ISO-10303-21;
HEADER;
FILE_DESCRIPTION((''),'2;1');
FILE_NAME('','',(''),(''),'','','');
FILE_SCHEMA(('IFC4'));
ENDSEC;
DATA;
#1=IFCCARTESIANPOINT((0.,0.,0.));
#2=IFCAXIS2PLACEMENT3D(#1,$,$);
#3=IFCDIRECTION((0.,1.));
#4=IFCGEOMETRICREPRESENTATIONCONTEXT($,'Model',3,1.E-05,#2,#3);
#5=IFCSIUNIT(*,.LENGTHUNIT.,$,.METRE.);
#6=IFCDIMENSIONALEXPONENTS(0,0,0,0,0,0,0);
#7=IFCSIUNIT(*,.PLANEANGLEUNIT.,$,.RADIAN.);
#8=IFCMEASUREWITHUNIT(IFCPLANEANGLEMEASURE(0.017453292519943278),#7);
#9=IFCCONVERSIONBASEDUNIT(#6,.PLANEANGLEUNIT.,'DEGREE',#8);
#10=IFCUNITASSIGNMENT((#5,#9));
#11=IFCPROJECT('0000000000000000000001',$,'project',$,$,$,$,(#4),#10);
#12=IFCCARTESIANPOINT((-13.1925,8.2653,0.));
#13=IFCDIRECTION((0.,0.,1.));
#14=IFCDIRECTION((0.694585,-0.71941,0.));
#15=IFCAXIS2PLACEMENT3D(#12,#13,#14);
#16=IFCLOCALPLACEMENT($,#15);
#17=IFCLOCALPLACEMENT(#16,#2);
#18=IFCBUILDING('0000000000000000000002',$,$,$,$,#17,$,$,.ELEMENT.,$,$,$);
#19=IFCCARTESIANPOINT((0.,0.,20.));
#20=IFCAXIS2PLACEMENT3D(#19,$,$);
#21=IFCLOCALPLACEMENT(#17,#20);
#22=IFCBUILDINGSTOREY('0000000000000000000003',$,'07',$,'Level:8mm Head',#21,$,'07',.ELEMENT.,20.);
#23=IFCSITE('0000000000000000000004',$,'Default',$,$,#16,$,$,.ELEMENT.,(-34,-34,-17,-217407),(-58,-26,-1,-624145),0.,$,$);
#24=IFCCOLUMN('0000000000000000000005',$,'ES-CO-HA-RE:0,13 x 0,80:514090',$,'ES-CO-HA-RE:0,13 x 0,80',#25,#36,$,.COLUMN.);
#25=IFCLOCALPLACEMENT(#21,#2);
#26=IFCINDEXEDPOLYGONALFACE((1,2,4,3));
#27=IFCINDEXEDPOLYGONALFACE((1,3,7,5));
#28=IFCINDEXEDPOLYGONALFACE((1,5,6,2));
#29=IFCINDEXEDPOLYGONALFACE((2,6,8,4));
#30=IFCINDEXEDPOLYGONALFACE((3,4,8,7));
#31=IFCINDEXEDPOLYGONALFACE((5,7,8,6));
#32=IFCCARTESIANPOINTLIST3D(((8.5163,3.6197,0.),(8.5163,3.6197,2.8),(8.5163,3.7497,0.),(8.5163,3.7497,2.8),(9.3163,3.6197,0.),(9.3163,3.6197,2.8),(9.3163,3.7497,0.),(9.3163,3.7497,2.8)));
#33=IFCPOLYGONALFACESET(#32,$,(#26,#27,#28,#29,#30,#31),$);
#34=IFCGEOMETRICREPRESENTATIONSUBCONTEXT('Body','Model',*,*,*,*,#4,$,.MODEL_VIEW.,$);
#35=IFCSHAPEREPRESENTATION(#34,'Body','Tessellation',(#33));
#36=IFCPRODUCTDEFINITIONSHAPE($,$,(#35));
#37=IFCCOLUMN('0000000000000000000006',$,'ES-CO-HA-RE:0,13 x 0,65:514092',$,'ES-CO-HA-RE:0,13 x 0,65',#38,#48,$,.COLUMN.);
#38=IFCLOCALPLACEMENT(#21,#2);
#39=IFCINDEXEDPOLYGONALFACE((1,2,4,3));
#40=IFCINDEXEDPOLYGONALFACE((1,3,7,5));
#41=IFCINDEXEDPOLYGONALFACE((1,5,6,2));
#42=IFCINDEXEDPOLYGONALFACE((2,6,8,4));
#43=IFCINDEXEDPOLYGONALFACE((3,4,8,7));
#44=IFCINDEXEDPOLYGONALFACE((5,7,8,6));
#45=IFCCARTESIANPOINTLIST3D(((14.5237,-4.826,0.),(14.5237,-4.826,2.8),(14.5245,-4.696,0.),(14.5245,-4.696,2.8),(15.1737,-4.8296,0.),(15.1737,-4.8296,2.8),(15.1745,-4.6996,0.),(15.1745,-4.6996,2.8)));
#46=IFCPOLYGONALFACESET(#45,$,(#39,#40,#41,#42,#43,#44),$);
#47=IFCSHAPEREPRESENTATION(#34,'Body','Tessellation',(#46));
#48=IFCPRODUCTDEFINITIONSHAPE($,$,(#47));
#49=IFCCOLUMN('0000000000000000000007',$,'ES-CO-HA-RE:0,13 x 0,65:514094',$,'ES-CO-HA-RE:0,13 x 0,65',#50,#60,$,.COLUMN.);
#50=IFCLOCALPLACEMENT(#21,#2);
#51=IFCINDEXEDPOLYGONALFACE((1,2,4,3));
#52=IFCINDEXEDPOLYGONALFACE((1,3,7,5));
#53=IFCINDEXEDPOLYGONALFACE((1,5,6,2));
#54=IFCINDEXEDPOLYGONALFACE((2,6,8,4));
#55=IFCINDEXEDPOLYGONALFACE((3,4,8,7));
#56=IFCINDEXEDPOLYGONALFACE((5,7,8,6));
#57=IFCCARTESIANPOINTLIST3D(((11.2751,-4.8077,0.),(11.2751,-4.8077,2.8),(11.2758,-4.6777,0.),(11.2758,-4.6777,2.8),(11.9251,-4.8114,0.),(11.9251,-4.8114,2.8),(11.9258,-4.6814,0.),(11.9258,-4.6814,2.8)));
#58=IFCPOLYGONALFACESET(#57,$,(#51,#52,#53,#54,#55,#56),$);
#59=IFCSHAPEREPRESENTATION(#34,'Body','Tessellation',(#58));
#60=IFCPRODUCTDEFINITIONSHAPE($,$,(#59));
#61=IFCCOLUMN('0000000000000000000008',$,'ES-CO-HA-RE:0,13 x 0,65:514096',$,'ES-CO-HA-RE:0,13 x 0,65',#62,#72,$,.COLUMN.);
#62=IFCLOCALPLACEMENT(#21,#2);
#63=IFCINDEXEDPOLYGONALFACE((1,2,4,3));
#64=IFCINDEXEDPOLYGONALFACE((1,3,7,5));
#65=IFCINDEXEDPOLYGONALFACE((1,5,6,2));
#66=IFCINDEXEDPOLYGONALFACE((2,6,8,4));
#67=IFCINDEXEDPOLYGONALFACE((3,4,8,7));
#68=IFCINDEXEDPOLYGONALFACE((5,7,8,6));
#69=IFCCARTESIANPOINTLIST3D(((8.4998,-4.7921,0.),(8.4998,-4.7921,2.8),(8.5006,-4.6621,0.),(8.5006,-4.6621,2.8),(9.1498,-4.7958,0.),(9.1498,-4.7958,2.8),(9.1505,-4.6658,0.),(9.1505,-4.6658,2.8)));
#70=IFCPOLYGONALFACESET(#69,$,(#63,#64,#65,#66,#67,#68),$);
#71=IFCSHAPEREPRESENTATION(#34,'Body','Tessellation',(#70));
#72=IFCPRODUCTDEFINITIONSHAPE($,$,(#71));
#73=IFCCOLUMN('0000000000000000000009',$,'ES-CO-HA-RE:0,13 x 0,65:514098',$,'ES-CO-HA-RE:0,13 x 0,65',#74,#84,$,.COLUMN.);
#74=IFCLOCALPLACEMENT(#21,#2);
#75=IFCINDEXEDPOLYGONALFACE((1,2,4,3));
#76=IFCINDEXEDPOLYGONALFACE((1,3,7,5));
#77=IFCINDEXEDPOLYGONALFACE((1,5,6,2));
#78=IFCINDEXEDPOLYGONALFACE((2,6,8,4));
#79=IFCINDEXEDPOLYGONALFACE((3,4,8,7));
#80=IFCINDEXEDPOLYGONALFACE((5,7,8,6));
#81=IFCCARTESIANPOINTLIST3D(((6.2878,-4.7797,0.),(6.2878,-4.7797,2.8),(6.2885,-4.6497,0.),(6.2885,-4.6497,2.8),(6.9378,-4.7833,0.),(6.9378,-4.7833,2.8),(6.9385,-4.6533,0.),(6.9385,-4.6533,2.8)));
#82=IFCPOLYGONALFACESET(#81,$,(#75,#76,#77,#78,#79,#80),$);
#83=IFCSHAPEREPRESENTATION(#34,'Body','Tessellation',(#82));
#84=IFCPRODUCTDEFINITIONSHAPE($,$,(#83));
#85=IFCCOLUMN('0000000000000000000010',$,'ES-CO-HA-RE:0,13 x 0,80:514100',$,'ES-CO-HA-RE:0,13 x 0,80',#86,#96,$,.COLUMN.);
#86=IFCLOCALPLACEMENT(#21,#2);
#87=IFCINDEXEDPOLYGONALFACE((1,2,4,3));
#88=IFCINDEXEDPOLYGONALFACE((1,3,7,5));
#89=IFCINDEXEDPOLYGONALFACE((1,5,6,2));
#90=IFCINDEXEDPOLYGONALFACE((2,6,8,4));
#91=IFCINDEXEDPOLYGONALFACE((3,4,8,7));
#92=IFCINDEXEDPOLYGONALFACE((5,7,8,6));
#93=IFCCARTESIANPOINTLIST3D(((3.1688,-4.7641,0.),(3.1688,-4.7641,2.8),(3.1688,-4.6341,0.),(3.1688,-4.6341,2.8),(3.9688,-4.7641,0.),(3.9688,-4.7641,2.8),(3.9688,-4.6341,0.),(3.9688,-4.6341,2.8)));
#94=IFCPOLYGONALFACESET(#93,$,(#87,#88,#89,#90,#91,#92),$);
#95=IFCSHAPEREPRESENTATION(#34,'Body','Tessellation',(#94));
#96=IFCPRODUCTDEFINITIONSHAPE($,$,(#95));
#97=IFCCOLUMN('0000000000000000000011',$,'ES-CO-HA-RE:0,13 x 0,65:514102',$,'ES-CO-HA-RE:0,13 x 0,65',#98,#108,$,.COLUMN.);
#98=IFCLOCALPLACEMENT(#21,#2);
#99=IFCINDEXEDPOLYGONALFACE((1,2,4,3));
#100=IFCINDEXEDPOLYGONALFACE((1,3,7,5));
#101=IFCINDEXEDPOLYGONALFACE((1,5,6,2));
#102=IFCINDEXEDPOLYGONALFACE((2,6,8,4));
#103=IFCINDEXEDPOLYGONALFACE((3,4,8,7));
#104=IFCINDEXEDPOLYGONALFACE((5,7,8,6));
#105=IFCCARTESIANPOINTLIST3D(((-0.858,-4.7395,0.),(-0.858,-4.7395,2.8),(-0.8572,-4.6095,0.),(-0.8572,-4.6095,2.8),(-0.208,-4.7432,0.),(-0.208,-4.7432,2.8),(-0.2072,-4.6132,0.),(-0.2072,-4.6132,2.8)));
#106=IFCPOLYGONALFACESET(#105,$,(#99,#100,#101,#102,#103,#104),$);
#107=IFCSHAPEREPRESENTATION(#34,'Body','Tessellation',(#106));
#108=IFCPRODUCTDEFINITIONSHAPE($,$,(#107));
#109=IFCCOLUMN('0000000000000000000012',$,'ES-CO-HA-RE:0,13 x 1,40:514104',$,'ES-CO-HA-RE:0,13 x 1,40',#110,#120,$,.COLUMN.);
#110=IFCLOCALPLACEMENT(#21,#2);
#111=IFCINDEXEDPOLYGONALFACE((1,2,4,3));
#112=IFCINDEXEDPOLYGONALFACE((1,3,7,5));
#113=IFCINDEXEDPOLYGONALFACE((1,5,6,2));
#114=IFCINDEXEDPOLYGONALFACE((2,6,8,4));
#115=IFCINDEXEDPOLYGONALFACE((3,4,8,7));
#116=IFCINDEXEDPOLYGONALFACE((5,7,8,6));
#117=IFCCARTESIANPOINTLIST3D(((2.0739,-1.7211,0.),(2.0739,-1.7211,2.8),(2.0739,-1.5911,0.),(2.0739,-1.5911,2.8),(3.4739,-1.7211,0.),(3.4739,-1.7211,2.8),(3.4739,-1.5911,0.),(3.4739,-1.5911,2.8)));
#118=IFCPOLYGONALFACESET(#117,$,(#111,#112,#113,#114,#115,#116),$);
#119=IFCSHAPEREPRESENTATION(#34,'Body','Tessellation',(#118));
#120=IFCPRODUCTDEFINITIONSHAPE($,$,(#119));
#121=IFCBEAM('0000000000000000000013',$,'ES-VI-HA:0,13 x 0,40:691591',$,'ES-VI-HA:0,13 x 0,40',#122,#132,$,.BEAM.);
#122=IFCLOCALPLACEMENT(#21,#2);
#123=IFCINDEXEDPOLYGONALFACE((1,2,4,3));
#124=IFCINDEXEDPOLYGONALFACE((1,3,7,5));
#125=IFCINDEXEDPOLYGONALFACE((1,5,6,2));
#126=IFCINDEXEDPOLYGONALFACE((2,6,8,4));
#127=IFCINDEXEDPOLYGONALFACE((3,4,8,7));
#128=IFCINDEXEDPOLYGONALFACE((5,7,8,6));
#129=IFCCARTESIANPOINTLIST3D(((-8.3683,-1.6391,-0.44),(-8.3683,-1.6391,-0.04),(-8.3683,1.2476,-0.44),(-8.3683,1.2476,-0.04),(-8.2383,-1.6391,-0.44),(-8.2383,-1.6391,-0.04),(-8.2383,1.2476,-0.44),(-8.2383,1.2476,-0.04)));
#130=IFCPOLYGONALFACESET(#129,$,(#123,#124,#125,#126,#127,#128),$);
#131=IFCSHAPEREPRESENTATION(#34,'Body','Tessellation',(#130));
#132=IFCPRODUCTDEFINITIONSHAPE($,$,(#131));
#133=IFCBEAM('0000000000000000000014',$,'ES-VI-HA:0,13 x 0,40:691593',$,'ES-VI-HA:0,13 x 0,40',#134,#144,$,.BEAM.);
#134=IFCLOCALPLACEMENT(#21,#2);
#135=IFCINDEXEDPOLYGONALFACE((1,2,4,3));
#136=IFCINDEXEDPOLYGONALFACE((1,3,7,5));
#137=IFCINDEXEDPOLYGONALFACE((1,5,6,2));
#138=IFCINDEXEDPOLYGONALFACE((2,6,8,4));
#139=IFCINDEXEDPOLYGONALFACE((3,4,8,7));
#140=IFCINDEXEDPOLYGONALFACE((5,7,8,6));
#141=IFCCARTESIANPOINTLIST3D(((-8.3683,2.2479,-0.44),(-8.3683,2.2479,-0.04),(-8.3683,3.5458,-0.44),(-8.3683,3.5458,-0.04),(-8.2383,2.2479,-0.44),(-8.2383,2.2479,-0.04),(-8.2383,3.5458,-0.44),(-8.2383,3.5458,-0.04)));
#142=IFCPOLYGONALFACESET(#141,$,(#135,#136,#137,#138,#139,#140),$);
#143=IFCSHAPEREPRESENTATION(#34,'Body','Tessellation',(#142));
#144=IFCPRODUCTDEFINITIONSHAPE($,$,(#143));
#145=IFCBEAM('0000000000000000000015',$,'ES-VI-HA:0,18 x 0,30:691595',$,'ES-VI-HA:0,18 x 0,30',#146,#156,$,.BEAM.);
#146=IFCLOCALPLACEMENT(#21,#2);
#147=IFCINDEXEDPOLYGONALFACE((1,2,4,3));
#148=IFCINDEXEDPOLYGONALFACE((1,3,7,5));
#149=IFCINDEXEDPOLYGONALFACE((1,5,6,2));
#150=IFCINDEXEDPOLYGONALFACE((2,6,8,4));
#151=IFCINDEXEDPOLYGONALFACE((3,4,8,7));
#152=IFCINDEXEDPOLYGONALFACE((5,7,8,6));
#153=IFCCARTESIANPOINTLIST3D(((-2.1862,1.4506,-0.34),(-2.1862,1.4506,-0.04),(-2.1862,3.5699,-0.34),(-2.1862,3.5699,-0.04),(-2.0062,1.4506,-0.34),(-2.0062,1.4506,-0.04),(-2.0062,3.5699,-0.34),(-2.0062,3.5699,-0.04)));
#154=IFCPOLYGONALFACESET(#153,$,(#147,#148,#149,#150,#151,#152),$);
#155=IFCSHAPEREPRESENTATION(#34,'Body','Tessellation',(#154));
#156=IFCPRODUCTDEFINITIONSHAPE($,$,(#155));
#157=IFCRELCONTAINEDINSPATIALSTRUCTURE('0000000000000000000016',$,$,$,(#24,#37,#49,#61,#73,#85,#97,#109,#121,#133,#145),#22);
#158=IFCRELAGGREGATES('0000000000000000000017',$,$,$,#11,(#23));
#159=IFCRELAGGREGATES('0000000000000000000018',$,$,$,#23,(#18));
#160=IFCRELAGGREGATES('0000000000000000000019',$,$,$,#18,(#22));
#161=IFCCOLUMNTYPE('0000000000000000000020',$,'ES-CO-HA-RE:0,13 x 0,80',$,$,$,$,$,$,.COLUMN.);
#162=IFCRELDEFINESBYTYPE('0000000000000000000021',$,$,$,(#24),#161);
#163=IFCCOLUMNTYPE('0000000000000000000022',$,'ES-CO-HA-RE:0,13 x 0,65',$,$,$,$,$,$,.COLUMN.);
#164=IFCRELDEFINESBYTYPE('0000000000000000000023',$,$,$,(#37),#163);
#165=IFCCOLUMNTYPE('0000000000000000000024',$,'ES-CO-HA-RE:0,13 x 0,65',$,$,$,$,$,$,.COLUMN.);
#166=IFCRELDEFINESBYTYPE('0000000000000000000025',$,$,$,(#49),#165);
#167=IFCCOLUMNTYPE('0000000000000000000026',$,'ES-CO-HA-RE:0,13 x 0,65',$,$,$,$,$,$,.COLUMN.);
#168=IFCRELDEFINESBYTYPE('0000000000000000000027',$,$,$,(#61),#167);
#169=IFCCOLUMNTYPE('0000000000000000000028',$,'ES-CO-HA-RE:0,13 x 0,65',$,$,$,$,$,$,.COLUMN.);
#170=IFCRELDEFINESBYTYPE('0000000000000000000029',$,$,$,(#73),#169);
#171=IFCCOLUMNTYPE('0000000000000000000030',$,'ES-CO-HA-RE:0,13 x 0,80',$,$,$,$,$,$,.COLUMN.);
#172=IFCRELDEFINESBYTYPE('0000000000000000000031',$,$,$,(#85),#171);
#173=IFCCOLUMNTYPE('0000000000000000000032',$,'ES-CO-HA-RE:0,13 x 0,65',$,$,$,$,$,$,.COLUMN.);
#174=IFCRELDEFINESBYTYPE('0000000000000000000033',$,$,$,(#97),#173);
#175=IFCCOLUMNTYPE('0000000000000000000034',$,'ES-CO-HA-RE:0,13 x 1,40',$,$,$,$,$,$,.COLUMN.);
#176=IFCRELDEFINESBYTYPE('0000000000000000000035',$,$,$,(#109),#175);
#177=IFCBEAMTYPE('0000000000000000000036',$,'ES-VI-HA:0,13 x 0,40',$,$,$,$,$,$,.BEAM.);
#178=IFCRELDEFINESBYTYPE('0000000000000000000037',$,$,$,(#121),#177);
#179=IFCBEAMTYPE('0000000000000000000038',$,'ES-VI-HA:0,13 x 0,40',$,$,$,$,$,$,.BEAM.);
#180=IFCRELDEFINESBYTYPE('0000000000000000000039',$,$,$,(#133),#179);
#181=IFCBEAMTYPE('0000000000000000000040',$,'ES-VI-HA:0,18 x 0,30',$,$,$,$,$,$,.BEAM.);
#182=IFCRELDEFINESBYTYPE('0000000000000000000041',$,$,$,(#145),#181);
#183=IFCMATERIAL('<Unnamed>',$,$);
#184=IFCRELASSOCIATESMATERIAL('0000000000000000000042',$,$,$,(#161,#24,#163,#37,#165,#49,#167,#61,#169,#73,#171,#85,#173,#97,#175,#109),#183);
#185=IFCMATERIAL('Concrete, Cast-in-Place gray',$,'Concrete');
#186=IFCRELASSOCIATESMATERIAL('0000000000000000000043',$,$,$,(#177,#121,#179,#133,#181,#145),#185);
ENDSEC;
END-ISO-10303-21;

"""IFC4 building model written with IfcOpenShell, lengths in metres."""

from ifc_helpers import new_model, entity, si_unit, converted_unit, direction, frame, origin, place, context, subcontext, project, spatial, indexed_curve, outline, extrude, source, transform, mapped, material, type_object, type_shapes, element, save


model = new_model("IFC4")

# Units and contexts
model_context = context("Model", 3, precision=1e-05, world=origin(), true_north=direction((0.0, 1.0)))
body_context = subcontext(model_context, "Body", "Model", "MODEL_VIEW")
ifc_project = project(units=[si_unit("LENGTHUNIT", "METRE"), converted_unit("PLANEANGLEUNIT", "DEGREE", entity("IfcPlaneAngleMeasure", 0.017453292519943278), si_unit("PLANEANGLEUNIT", "RADIAN"), dimensions=[0, 0, 0, 0, 0, 0, 0])], contexts=[model_context])

# Site, building, storey
site_placement = place(None, frame((-13.1925, 8.2653, 0.0), z_axis=(0.0, 0.0, 1.0), x_axis=(0.694585, -0.71941, 0.0)))
site = spatial("IfcSite", under=ifc_project, at=site_placement, Name="Default", CompositionType="ELEMENT", RefLatitude=(-34, -34, -17, -217407), RefLongitude=(-58, -26, -1, -624145), RefElevation=0.0)
building_placement = place(site_placement, origin())
building = spatial("IfcBuilding", under=site, at=building_placement, CompositionType="ELEMENT")
storey_placement = place(building_placement, frame((0.0, 0.0, 20.0)))
storey = spatial("IfcBuildingStorey", under=building, at=storey_placement, Name="07", ObjectType="Level:8mm Head", LongName="07", CompositionType="ELEMENT", Elevation=20.0)

# Columns
ifc_material_1 = material(Name="<Unnamed>")
column_type_1 = type_object("IfcColumnType", Name="ES-CO-HA-RE:0,13 x 0,80", PredefinedType="COLUMN", material=ifc_material_1)
shared_shape_1 = source(origin(), body_context, "Body", "SweptSolid", [
    extrude(outline(indexed_curve([(-0.4, -0.065), (0.4, -0.065), (0.4, 0.065), (-0.4, 0.065), (-0.4, -0.065)], self_intersect=False)), frame((8.9163, 3.6847, 20.0), z_axis=(0.0, 0.0, 1.0), x_axis=(-1.0, 0.0, 0.0)), (0.0, 0.0, 1.0), 2.8),
])
type_shapes(column_type_1, [shared_shape_1])
column_1_placement = place(storey_placement, frame((0.0, 0.0, -20.0)))
element("IfcColumn", 1, at=column_1_placement, inside=storey, type_object=column_type_1, material=ifc_material_1, Name="ES-CO-HA-RE:0,13 x 0,80:514090", ObjectType="ES-CO-HA-RE:0,13 x 0,80", PredefinedType="COLUMN", context=body_context, shape_type="MappedRepresentation", body=[
    mapped(shared_shape_1, transform((0.0, 0.0, 0.0), scale=1.0)),
])
column_type_2 = type_object("IfcColumnType", Name="ES-CO-HA-RE:0,13 x 0,65", PredefinedType="COLUMN", material=ifc_material_1)
shared_shape_2 = source(origin(), body_context, "Body", "SweptSolid", [
    extrude(outline(indexed_curve([(-0.325, -0.065), (0.325, -0.065), (0.325, 0.065), (-0.325, 0.065), (-0.325, -0.065)], self_intersect=False)), frame((14.8491, -4.7628, 20.0), z_axis=(0.0, 0.0, 1.0), x_axis=(-0.999984, 0.005619, 0.0)), (0.0, 0.0, 1.0), 2.8),
])
type_shapes(column_type_2, [shared_shape_2])
column_2_placement = place(storey_placement, frame((0.0, 0.0, -20.0)))
element("IfcColumn", 2, at=column_2_placement, inside=storey, type_object=column_type_2, material=ifc_material_1, Name="ES-CO-HA-RE:0,13 x 0,65:514092", ObjectType="ES-CO-HA-RE:0,13 x 0,65", PredefinedType="COLUMN", context=body_context, shape_type="MappedRepresentation", body=[
    mapped(shared_shape_2, transform((0.0, 0.0, 0.0), scale=1.0)),
])
column_type_3 = type_object("IfcColumnType", Name="ES-CO-HA-RE:0,13 x 0,65", PredefinedType="COLUMN", material=ifc_material_1)
shared_shape_3 = source(origin(), body_context, "Body", "SweptSolid", [
    extrude(outline(indexed_curve([(-0.325, -0.065), (0.325, -0.065), (0.325, 0.065), (-0.325, 0.065), (-0.325, -0.065)], self_intersect=False)), frame((11.6005, -4.7445, 20.0), z_axis=(0.0, 0.0, 1.0), x_axis=(-0.999984, 0.005619, 0.0)), (0.0, 0.0, 1.0), 2.8),
])
type_shapes(column_type_3, [shared_shape_3])
column_3_placement = place(storey_placement, frame((0.0, 0.0, -20.0)))
element("IfcColumn", 3, at=column_3_placement, inside=storey, type_object=column_type_3, material=ifc_material_1, Name="ES-CO-HA-RE:0,13 x 0,65:514094", ObjectType="ES-CO-HA-RE:0,13 x 0,65", PredefinedType="COLUMN", context=body_context, shape_type="MappedRepresentation", body=[
    mapped(shared_shape_3, transform((0.0, 0.0, 0.0), scale=1.0)),
])
column_type_4 = type_object("IfcColumnType", Name="ES-CO-HA-RE:0,13 x 0,65", PredefinedType="COLUMN", material=ifc_material_1)
shared_shape_4 = source(origin(), body_context, "Body", "SweptSolid", [
    extrude(outline(indexed_curve([(-0.325, -0.065), (0.325, -0.065), (0.325, 0.065), (-0.325, 0.065), (-0.325, -0.065)], self_intersect=False)), frame((8.8252, -4.7289, 20.0), z_axis=(0.0, 0.0, 1.0), x_axis=(-0.999984, 0.005619, 0.0)), (0.0, 0.0, 1.0), 2.8),
])
type_shapes(column_type_4, [shared_shape_4])
column_4_placement = place(storey_placement, frame((0.0, 0.0, -20.0)))
element("IfcColumn", 4, at=column_4_placement, inside=storey, type_object=column_type_4, material=ifc_material_1, Name="ES-CO-HA-RE:0,13 x 0,65:514096", ObjectType="ES-CO-HA-RE:0,13 x 0,65", PredefinedType="COLUMN", context=body_context, shape_type="MappedRepresentation", body=[
    mapped(shared_shape_4, transform((0.0, 0.0, 0.0), scale=1.0)),
])
column_type_5 = type_object("IfcColumnType", Name="ES-CO-HA-RE:0,13 x 0,65", PredefinedType="COLUMN", material=ifc_material_1)
shared_shape_5 = source(origin(), body_context, "Body", "SweptSolid", [
    extrude(outline(indexed_curve([(-0.325, -0.065), (0.325, -0.065), (0.325, 0.065), (-0.325, 0.065), (-0.325, -0.065)], self_intersect=False)), frame((6.6131, -4.7165, 20.0), z_axis=(0.0, 0.0, 1.0), x_axis=(-0.999984, 0.005619, 0.0)), (0.0, 0.0, 1.0), 2.8),
])
type_shapes(column_type_5, [shared_shape_5])
column_5_placement = place(storey_placement, frame((0.0, 0.0, -20.0)))
element("IfcColumn", 5, at=column_5_placement, inside=storey, type_object=column_type_5, material=ifc_material_1, Name="ES-CO-HA-RE:0,13 x 0,65:514098", ObjectType="ES-CO-HA-RE:0,13 x 0,65", PredefinedType="COLUMN", context=body_context, shape_type="MappedRepresentation", body=[
    mapped(shared_shape_5, transform((0.0, 0.0, 0.0), scale=1.0)),
])
column_type_6 = type_object("IfcColumnType", Name="ES-CO-HA-RE:0,13 x 0,80", PredefinedType="COLUMN", material=ifc_material_1)
shared_shape_6 = source(origin(), body_context, "Body", "SweptSolid", [
    extrude(outline(indexed_curve([(-0.4, -0.065), (0.4, -0.065), (0.4, 0.065), (-0.4, 0.065), (-0.4, -0.065)], self_intersect=False)), frame((3.5688, -4.6991, 20.0), z_axis=(0.0, 0.0, 1.0), x_axis=(-1.0, 0.0, 0.0)), (0.0, 0.0, 1.0), 2.8),
])
type_shapes(column_type_6, [shared_shape_6])
column_6_placement = place(storey_placement, frame((0.0, 0.0, -20.0)))
element("IfcColumn", 6, at=column_6_placement, inside=storey, type_object=column_type_6, material=ifc_material_1, Name="ES-CO-HA-RE:0,13 x 0,80:514100", ObjectType="ES-CO-HA-RE:0,13 x 0,80", PredefinedType="COLUMN", context=body_context, shape_type="MappedRepresentation", body=[
    mapped(shared_shape_6, transform((0.0, 0.0, 0.0), scale=1.0)),
])
column_type_7 = type_object("IfcColumnType", Name="ES-CO-HA-RE:0,13 x 0,65", PredefinedType="COLUMN", material=ifc_material_1)
shared_shape_7 = source(origin(), body_context, "Body", "SweptSolid", [
    extrude(outline(indexed_curve([(-0.325, -0.065), (0.325, -0.065), (0.325, 0.065), (-0.325, 0.065), (-0.325, -0.065)], self_intersect=False)), frame((-0.5326, -4.6764, 20.0), z_axis=(0.0, 0.0, 1.0), x_axis=(-0.999984, 0.005619, 0.0)), (0.0, 0.0, 1.0), 2.8),
])
type_shapes(column_type_7, [shared_shape_7])
column_7_placement = place(storey_placement, frame((0.0, 0.0, -20.0)))
element("IfcColumn", 7, at=column_7_placement, inside=storey, type_object=column_type_7, material=ifc_material_1, Name="ES-CO-HA-RE:0,13 x 0,65:514102", ObjectType="ES-CO-HA-RE:0,13 x 0,65", PredefinedType="COLUMN", context=body_context, shape_type="MappedRepresentation", body=[
    mapped(shared_shape_7, transform((0.0, 0.0, 0.0), scale=1.0)),
])
column_type_8 = type_object("IfcColumnType", Name="ES-CO-HA-RE:0,13 x 1,40", PredefinedType="COLUMN", material=ifc_material_1)
shared_shape_8 = source(origin(), body_context, "Body", "SweptSolid", [
    extrude(outline(indexed_curve([(-0.7, -0.065), (0.7, -0.065), (0.7, 0.065), (-0.7, 0.065), (-0.7, -0.065)], self_intersect=False)), frame((2.7739, -1.6561, 20.0), z_axis=(0.0, 0.0, 1.0), x_axis=(-1.0, 0.0, 0.0)), (0.0, 0.0, 1.0), 2.8),
])
type_shapes(column_type_8, [shared_shape_8])
column_8_placement = place(storey_placement, frame((0.0, 0.0, -20.0)))
element("IfcColumn", 8, at=column_8_placement, inside=storey, type_object=column_type_8, material=ifc_material_1, Name="ES-CO-HA-RE:0,13 x 1,40:514104", ObjectType="ES-CO-HA-RE:0,13 x 1,40", PredefinedType="COLUMN", context=body_context, shape_type="MappedRepresentation", body=[
    mapped(shared_shape_8, transform((0.0, 0.0, 0.0), scale=1.0)),
])

# Beams
ifc_material_2 = material(Name="Concrete, Cast-in-Place gray", Category="Concrete")
beam_type_1 = type_object("IfcBeamType", Name="ES-VI-HA:0,13 x 0,40", PredefinedType="BEAM", material=ifc_material_2)
shared_shape_9 = source(origin(), body_context, "Body", "SweptSolid", [
    extrude(outline(indexed_curve([(-0.065, -0.2), (0.065, -0.2), (0.065, 0.2), (-0.065, 0.2), (-0.065, -0.2)], self_intersect=False)), frame((-8.3033, -1.6391, 19.76), z_axis=(0.0, 1.0, 0.0), x_axis=(-1.0, 0.0, 0.0)), (0.0, 0.0, 1.0), 2.8867),
])
type_shapes(beam_type_1, [shared_shape_9])
beam_1_placement = place(storey_placement, frame((0.0, 0.0, -20.0)))
element("IfcBeam", 9, at=beam_1_placement, inside=storey, type_object=beam_type_1, material=ifc_material_2, Name="ES-VI-HA:0,13 x 0,40:691591", ObjectType="ES-VI-HA:0,13 x 0,40", PredefinedType="BEAM", context=body_context, shape_type="MappedRepresentation", body=[
    mapped(shared_shape_9, transform((0.0, 0.0, 0.0), scale=1.0)),
])
beam_type_2 = type_object("IfcBeamType", Name="ES-VI-HA:0,13 x 0,40", PredefinedType="BEAM", material=ifc_material_2)
shared_shape_10 = source(origin(), body_context, "Body", "SweptSolid", [
    extrude(outline(indexed_curve([(-0.065, -0.2), (0.065, -0.2), (0.065, 0.2), (-0.065, 0.2), (-0.065, -0.2)], self_intersect=False)), frame((-8.3033, 2.2479, 19.76), z_axis=(0.0, 1.0, 0.0), x_axis=(-1.0, 0.0, 0.0)), (0.0, 0.0, 1.0), 1.298),
])
type_shapes(beam_type_2, [shared_shape_10])
beam_2_placement = place(storey_placement, frame((0.0, 0.0, -20.0)))
element("IfcBeam", 10, at=beam_2_placement, inside=storey, type_object=beam_type_2, material=ifc_material_2, Name="ES-VI-HA:0,13 x 0,40:691593", ObjectType="ES-VI-HA:0,13 x 0,40", PredefinedType="BEAM", context=body_context, shape_type="MappedRepresentation", body=[
    mapped(shared_shape_10, transform((0.0, 0.0, 0.0), scale=1.0)),
])
beam_type_3 = type_object("IfcBeamType", Name="ES-VI-HA:0,18 x 0,30", PredefinedType="BEAM", material=ifc_material_2)
shared_shape_11 = source(origin(), body_context, "Body", "SweptSolid", [
    extrude(outline(indexed_curve([(-0.09, -0.15), (0.09, -0.15), (0.09, 0.15), (-0.09, 0.15), (-0.09, -0.15)], self_intersect=False)), frame((-2.0962, 3.5699, 19.81), z_axis=(0.0, -1.0, 0.0), x_axis=(-1.0, 0.0, 0.0)), (0.0, 0.0, 1.0), 2.1193),
])
type_shapes(beam_type_3, [shared_shape_11])
beam_3_placement = place(storey_placement, frame((0.0, 0.0, -20.0)))
element("IfcBeam", 11, at=beam_3_placement, inside=storey, type_object=beam_type_3, material=ifc_material_2, Name="ES-VI-HA:0,18 x 0,30:691595", ObjectType="ES-VI-HA:0,18 x 0,30", PredefinedType="BEAM", context=body_context, shape_type="MappedRepresentation", body=[
    mapped(shared_shape_11, transform((0.0, 0.0, 0.0), scale=1.0)),
])

save(model, "model.ifc")
